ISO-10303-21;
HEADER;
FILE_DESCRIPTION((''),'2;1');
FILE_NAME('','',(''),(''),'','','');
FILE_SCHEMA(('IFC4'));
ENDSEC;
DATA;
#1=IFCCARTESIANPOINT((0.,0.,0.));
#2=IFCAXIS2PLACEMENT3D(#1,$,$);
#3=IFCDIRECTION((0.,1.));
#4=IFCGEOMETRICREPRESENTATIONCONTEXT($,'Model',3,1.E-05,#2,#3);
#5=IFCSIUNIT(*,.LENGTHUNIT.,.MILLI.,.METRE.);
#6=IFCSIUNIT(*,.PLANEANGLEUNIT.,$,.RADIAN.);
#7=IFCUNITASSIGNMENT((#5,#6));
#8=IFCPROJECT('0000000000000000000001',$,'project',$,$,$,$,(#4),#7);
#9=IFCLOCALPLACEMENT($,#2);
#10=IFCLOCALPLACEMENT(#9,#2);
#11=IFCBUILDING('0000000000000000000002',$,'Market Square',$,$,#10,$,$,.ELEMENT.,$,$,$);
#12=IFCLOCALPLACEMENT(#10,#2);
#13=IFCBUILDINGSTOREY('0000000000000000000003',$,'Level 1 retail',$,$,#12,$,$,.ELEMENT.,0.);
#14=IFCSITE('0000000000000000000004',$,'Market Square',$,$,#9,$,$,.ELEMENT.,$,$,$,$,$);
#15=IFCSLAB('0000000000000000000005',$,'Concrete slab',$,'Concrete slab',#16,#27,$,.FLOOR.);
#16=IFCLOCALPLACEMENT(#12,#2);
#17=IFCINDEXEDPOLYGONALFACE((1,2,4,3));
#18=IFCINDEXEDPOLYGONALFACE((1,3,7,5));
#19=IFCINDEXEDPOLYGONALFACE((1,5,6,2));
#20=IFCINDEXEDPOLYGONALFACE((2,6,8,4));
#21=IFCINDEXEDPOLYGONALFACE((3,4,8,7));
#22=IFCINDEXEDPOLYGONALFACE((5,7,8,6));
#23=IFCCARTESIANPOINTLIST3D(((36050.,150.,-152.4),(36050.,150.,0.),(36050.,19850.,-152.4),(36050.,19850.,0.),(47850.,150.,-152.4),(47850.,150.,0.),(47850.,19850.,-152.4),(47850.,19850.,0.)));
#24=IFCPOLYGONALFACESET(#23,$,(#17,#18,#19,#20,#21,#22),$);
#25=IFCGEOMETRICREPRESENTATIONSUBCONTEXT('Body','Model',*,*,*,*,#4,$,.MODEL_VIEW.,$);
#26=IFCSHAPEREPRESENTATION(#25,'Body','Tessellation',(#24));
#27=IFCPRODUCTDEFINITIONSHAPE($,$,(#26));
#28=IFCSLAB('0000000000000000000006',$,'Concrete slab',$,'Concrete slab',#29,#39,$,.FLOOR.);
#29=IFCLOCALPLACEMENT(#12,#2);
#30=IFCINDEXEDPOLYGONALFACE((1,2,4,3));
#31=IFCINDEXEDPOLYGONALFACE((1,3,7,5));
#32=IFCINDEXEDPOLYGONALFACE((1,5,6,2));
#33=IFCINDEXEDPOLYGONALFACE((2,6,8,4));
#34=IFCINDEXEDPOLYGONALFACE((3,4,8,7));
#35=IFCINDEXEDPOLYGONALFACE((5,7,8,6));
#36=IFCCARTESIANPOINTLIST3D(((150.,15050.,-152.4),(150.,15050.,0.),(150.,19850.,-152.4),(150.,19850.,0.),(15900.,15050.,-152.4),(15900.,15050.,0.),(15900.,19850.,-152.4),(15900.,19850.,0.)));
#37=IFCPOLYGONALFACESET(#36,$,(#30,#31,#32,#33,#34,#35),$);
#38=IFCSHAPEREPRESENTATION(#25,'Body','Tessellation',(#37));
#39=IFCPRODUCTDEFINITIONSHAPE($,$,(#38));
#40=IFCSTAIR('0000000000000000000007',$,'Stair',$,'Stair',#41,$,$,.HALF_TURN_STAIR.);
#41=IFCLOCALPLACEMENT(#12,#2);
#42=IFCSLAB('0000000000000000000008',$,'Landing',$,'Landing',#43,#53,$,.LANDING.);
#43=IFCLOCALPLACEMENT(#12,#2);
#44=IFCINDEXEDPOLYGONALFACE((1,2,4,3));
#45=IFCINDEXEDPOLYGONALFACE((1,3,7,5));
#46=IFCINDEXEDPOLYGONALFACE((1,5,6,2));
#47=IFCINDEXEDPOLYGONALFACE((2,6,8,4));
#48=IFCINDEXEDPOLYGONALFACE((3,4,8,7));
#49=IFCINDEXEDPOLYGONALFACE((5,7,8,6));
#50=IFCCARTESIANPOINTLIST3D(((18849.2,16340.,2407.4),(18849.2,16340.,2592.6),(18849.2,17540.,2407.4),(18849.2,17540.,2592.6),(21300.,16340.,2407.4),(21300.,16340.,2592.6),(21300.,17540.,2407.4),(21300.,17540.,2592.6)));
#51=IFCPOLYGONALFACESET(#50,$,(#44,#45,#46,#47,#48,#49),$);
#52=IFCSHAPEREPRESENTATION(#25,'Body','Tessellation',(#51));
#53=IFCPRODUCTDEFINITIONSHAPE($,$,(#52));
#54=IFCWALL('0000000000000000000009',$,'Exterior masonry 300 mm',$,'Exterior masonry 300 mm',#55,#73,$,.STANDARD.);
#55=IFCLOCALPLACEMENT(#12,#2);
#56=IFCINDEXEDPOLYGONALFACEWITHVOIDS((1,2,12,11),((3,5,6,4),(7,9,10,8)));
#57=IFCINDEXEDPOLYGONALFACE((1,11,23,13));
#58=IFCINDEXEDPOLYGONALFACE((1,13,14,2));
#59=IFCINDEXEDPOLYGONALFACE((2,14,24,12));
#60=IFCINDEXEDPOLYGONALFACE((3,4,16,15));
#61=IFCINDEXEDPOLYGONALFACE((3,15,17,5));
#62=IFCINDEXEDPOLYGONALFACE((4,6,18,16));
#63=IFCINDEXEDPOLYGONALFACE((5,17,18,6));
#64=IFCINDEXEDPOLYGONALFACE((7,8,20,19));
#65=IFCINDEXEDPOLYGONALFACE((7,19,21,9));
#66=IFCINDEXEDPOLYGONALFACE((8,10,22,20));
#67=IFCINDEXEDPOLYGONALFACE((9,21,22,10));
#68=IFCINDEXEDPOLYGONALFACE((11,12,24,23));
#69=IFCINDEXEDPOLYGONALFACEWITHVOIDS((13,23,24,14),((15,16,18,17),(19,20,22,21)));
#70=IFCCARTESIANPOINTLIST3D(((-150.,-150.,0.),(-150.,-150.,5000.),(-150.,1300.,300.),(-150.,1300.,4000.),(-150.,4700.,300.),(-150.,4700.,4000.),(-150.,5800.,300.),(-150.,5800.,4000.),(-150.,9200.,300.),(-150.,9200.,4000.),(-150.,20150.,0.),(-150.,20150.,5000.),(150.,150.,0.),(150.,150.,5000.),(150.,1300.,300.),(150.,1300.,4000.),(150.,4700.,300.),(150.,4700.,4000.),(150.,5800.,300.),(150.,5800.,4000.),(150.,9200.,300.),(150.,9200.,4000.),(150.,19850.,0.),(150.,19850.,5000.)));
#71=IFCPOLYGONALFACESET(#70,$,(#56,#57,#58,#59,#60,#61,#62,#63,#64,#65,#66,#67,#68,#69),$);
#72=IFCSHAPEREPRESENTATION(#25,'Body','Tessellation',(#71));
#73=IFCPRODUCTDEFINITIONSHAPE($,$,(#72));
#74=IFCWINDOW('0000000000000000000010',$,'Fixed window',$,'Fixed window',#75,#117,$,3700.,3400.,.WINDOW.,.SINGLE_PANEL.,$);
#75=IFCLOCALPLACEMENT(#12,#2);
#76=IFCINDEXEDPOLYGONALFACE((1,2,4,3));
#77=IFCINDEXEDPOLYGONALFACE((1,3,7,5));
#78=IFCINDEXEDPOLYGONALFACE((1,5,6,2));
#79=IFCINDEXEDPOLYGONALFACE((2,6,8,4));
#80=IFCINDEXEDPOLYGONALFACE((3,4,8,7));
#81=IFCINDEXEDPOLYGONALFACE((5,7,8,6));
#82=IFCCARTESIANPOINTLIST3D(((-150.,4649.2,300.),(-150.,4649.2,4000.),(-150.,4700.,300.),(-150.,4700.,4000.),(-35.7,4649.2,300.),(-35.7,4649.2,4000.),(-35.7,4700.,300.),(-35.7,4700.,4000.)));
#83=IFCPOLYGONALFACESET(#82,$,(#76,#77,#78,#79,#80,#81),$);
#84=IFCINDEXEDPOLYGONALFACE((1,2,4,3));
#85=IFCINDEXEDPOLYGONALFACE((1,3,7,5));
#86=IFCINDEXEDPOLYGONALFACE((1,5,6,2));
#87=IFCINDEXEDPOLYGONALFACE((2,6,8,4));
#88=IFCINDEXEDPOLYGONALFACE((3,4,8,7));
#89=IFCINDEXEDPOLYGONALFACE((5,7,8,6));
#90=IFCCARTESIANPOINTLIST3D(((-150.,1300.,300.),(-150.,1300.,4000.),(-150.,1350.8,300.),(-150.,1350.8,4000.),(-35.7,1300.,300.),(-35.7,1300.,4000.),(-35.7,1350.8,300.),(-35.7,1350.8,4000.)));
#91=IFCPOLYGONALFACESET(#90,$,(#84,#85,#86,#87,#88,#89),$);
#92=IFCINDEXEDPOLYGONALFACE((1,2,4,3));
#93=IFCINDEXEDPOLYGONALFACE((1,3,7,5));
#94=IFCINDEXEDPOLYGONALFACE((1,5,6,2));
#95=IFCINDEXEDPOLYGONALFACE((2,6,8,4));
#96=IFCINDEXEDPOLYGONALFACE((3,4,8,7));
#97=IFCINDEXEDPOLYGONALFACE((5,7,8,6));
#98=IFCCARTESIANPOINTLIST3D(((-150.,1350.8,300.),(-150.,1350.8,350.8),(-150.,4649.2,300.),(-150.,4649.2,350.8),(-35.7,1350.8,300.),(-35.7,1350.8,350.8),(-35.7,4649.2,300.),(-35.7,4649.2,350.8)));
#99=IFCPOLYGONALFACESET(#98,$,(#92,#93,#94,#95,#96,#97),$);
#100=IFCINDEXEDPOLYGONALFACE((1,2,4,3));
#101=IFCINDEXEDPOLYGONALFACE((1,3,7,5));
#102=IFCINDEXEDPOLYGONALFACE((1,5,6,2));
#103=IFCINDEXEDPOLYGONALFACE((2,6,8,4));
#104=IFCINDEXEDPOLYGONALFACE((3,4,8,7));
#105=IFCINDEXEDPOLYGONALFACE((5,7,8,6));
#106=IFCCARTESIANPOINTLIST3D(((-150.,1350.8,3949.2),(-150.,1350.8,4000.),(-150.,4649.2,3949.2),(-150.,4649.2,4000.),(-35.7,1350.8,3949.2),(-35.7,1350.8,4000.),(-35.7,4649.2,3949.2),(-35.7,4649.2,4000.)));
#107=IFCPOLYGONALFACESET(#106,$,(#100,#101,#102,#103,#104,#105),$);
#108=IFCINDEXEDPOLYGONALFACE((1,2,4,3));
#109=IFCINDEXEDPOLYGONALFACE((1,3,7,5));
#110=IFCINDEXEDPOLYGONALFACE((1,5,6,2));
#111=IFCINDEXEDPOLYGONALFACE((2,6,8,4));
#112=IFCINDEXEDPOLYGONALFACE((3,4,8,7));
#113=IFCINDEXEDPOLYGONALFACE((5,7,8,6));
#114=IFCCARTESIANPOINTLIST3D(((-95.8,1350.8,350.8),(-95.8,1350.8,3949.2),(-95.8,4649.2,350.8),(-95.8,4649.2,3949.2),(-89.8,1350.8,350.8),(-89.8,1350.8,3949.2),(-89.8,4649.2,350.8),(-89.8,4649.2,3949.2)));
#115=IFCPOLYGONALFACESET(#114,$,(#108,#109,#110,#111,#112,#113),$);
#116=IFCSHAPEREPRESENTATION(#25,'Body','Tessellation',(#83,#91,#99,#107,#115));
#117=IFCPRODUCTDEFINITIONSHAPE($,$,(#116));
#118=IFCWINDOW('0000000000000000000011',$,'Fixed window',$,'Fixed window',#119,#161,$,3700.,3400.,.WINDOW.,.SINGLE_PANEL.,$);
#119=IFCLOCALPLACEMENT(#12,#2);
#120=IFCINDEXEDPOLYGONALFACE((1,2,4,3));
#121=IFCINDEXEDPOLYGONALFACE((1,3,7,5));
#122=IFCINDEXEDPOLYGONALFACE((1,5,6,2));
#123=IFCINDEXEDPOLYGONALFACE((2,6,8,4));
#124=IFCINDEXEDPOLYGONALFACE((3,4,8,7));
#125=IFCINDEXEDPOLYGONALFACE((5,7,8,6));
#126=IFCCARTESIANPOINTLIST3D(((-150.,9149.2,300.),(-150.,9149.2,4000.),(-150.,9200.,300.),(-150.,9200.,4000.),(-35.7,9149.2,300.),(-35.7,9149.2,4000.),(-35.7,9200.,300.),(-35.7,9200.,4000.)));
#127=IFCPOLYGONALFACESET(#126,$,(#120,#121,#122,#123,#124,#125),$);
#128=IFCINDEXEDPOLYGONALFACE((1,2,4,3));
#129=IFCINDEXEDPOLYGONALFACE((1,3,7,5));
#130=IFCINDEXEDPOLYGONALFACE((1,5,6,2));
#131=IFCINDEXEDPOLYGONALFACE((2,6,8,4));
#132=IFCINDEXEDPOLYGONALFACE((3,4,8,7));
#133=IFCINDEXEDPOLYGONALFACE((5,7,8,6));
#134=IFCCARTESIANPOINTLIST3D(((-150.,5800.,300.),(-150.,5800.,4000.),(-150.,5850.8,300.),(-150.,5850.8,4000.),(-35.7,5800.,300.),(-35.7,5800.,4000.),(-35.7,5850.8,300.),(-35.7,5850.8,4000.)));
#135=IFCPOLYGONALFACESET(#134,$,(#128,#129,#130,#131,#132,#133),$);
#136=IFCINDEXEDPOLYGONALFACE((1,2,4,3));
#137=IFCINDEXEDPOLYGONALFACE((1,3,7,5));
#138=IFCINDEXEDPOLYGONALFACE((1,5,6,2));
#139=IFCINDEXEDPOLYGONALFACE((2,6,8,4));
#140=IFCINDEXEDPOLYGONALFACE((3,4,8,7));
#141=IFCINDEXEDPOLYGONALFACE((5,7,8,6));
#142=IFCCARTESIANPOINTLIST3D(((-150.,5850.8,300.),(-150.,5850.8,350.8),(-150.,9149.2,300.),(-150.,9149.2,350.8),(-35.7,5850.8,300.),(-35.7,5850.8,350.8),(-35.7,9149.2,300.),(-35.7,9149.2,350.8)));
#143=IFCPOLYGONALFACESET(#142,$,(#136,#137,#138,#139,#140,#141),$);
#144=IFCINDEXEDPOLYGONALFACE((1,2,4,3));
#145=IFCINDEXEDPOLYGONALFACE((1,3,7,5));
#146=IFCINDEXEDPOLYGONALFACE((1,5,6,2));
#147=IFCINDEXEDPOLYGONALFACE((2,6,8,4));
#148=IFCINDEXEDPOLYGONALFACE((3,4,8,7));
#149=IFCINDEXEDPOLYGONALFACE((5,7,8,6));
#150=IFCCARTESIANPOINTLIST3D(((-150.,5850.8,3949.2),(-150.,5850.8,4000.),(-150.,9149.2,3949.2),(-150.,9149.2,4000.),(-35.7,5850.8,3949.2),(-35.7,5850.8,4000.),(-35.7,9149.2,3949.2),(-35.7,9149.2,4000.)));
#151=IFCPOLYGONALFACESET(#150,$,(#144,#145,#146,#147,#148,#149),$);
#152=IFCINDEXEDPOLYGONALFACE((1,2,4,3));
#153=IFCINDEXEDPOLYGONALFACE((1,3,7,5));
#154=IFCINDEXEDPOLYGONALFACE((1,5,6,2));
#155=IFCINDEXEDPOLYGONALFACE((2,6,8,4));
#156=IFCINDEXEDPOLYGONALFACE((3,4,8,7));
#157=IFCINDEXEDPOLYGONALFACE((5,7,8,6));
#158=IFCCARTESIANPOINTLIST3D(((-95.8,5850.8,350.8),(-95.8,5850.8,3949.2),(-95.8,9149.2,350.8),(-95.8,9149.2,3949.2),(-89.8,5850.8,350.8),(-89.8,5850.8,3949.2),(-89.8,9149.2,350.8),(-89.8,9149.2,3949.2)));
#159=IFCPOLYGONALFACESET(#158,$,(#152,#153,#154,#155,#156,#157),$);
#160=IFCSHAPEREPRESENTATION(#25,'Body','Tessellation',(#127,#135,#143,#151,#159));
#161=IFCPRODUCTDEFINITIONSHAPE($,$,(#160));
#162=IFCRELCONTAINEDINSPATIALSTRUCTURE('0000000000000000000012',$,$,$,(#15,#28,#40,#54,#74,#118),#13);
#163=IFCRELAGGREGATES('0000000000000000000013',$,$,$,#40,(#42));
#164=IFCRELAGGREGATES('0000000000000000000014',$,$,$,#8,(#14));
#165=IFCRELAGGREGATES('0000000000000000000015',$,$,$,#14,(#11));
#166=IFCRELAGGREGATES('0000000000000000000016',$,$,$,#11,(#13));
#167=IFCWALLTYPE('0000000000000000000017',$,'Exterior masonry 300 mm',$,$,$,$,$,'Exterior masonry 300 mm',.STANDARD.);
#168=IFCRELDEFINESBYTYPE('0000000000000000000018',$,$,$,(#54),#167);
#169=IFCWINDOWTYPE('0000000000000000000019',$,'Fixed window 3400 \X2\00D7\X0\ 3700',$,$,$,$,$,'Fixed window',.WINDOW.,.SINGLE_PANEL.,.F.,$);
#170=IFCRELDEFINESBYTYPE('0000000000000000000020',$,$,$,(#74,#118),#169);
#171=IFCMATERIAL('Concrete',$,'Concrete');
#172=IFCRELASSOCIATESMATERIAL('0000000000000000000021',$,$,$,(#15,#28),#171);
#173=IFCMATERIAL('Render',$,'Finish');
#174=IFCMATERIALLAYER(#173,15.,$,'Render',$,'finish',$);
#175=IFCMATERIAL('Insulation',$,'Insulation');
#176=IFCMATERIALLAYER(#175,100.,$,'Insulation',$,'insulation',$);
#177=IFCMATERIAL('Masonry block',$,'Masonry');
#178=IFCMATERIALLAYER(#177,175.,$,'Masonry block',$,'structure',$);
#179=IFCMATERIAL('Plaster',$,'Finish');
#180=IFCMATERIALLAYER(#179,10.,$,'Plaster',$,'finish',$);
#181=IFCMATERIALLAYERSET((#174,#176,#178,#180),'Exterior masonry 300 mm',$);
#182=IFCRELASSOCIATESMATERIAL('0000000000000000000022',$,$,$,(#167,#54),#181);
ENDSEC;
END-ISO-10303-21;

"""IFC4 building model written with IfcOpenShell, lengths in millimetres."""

from ifc_helpers import new_model, si_unit, direction, frame, origin, origin_with_axes, place, context, subcontext, project, spatial, polyline, outline, extrude, material, layer, layer_set, layer_usage, type_object, element, fill, aggregate, save


model = new_model("IFC4")

# Units and contexts
model_context = context("Model", 3, precision=1e-05, world=origin(), true_north=direction((0.0, 1.0)))
body_context = subcontext(model_context, "Body", "Model", "MODEL_VIEW")
ifc_project = project(units=[si_unit("LENGTHUNIT", "METRE", prefix="MILLI"), si_unit("PLANEANGLEUNIT", "RADIAN")], contexts=[model_context])

# Site, building, storey
site_placement = place(None, origin())
site = spatial("IfcSite", under=ifc_project, at=site_placement, Name="Market Square", CompositionType="ELEMENT")
building_placement = place(site_placement, origin())
building = spatial("IfcBuilding", under=site, at=building_placement, Name="Market Square", CompositionType="ELEMENT")
storey_placement = place(building_placement, origin())
storey = spatial("IfcBuildingStorey", under=building, at=storey_placement, Name="Level 1 retail", CompositionType="ELEMENT", Elevation=0.0)

# Slabs
ifc_material_1 = material(Name="Concrete", Category="Concrete")
slab_1_placement = place(storey_placement, origin_with_axes())
element("IfcSlab", 1, at=slab_1_placement, inside=storey, material=ifc_material_1, Name="Concrete slab", ObjectType="Concrete slab", PredefinedType="FLOOR", context=body_context, shape_type="SweptSolid", body=[
    extrude(outline(polyline([(36050.0, 150.0), (47850.0, 150.0), (47850.0, 19850.0), (36050.0, 19850.0), (36050.0, 150.0)])), frame((0.0, 0.0, -152.4)), (0.0, 0.0, 1.0), 152.4),
])
slab_2_placement = place(storey_placement, origin_with_axes())
element("IfcSlab", 2, at=slab_2_placement, inside=storey, material=ifc_material_1, Name="Concrete slab", ObjectType="Concrete slab", PredefinedType="FLOOR", context=body_context, shape_type="SweptSolid", body=[
    extrude(outline(polyline([(15900.0, 19850.0), (150.0, 19850.0), (150.0, 15050.0), (15900.0, 15050.0), (15900.0, 19850.0)])), frame((0.0, 0.0, -152.4)), (0.0, 0.0, 1.0), 152.4),
])

# Stair, slab
stair_placement = place(storey_placement, origin_with_axes())
stair = element("IfcStair", 3, at=stair_placement, inside=storey, Name="Stair", ObjectType="Stair", PredefinedType="HALF_TURN_STAIR")
slab_3_placement = place(storey_placement, origin_with_axes())
slab_3 = element("IfcSlab", 4, at=slab_3_placement, Name="Landing", ObjectType="Landing", PredefinedType="LANDING", context=body_context, shape_type="SweptSolid", body=[
    extrude(outline(polyline([(21300.0, 16340.0), (21300.0, 17540.0), (18849.2, 17540.0), (18849.2, 16340.0), (21300.0, 16340.0)])), frame((0.0, 0.0, 2407.4)), (0.0, 0.0, 1.0), 185.2),
])

# Wall, openings, windows
ifc_material_2 = material(Name="Render", Category="Finish")
ifc_layer_1 = layer(ifc_material_2, 15.0, Name="Render", Category="finish")
ifc_material_3 = material(Name="Insulation", Category="Insulation")
ifc_layer_2 = layer(ifc_material_3, 100.0, Name="Insulation", Category="insulation")
ifc_material_4 = material(Name="Masonry block", Category="Masonry")
ifc_layer_3 = layer(ifc_material_4, 175.0, Name="Masonry block", Category="structure")
ifc_material_5 = material(Name="Plaster", Category="Finish")
ifc_layer_4 = layer(ifc_material_5, 10.0, Name="Plaster", Category="finish")
ifc_layer_set_1 = layer_set([ifc_layer_1, ifc_layer_2, ifc_layer_3, ifc_layer_4], Name="Exterior masonry 300 mm")
ifc_layer_usage_1 = layer_usage(ifc_layer_set_1, "AXIS2", "POSITIVE", -150.0)
wall_type_1 = type_object("IfcWallType", Name="Exterior masonry 300 mm", ElementType="Exterior masonry 300 mm", PredefinedType="STANDARD", material=ifc_layer_set_1)
wall_1_placement = place(storey_placement, frame((0.0, 20000.0, 0.0), z_axis=(0.0, 0.0, 1.0), x_axis=(0.0, -1.0, 0.0)))
wall_1 = element("IfcWall", 5, at=wall_1_placement, inside=storey, type_object=wall_type_1, material=ifc_layer_usage_1, Name="Exterior masonry 300 mm", ObjectType="Exterior masonry 300 mm", PredefinedType="STANDARD", context=body_context, shape_type="SweptSolid", body=[
    extrude(outline(polyline([(-150.0, -150.0), (20150.0, -150.0), (19850.0, 150.0), (150.0, 150.0), (-150.0, -150.0)])), origin(), (0.0, 0.0, 1.0), 5000.0),
])
opening_1_placement = place(wall_1_placement, frame((15300.0, 0.0, 300.0), z_axis=(0.0, 0.0, 1.0), x_axis=(1.0, 0.0, 0.0)))
opening_1 = element("IfcOpeningElement", 6, at=opening_1_placement, cuts=wall_1, PredefinedType="OPENING", context=body_context, shape_type="SweptSolid", body=[
    extrude(outline(polyline([(0.0, -160.0), (3400.0, -160.0), (3400.0, 160.0), (0.0, 160.0), (0.0, -160.0)])), origin(), (0.0, 0.0, 1.0), 3700.0),
])
opening_2_placement = place(wall_1_placement, frame((10800.0, 0.0, 300.0), z_axis=(0.0, 0.0, 1.0), x_axis=(1.0, 0.0, 0.0)))
opening_2 = element("IfcOpeningElement", 7, at=opening_2_placement, cuts=wall_1, PredefinedType="OPENING", context=body_context, shape_type="SweptSolid", body=[
    extrude(outline(polyline([(0.0, -160.0), (3400.0, -160.0), (3400.0, 160.0), (0.0, 160.0), (0.0, -160.0)])), origin(), (0.0, 0.0, 1.0), 3700.0),
])
window_type = type_object("IfcWindowType", Name="Fixed window 3400 × 3700", ElementType="Fixed window", ParameterTakesPrecedence=False, PartitioningType="SINGLE_PANEL", PredefinedType="WINDOW")
window_1_placement = place(opening_1_placement, origin_with_axes())
window_1 = element("IfcWindow", 8, at=window_1_placement, inside=storey, type_object=window_type, Name="Fixed window", ObjectType="Fixed window", OverallHeight=3700.0, OverallWidth=3400.0, PartitioningType="SINGLE_PANEL", PredefinedType="WINDOW", context=body_context, shape_type="SweptSolid", body=[
    extrude(outline(polyline([(0.0, -150.0), (50.8, -150.0), (50.8, -35.7), (0.0, -35.7), (0.0, -150.0)])), origin(), (0.0, 0.0, 1.0), 3700.0),
    extrude(outline(polyline([(3349.2, -150.0), (3400.0, -150.0), (3400.0, -35.7), (3349.2, -35.7), (3349.2, -150.0)])), origin(), (0.0, 0.0, 1.0), 3700.0),
    extrude(outline(polyline([(50.8, -150.0), (3349.2, -150.0), (3349.2, -35.7), (50.8, -35.7), (50.8, -150.0)])), origin(), (0.0, 0.0, 1.0), 50.8),
    extrude(outline(polyline([(50.8, -150.0), (3349.2, -150.0), (3349.2, -35.7), (50.8, -35.7), (50.8, -150.0)])), frame((0.0, 0.0, 3649.2)), (0.0, 0.0, 1.0), 50.8),
    extrude(outline(polyline([(50.8, -95.8), (3349.2, -95.8), (3349.2, -89.8), (50.8, -89.8), (50.8, -95.8)])), frame((0.0, 0.0, 50.8)), (0.0, 0.0, 1.0), 3598.4),
])
fill(opening_1, window_1)
window_2_placement = place(opening_2_placement, origin_with_axes())
window_2 = element("IfcWindow", 9, at=window_2_placement, inside=storey, type_object=window_type, Name="Fixed window", ObjectType="Fixed window", OverallHeight=3700.0, OverallWidth=3400.0, PartitioningType="SINGLE_PANEL", PredefinedType="WINDOW", context=body_context, shape_type="SweptSolid", body=[
    extrude(outline(polyline([(0.0, -150.0), (50.8, -150.0), (50.8, -35.7), (0.0, -35.7), (0.0, -150.0)])), origin(), (0.0, 0.0, 1.0), 3700.0),
    extrude(outline(polyline([(3349.2, -150.0), (3400.0, -150.0), (3400.0, -35.7), (3349.2, -35.7), (3349.2, -150.0)])), origin(), (0.0, 0.0, 1.0), 3700.0),
    extrude(outline(polyline([(50.8, -150.0), (3349.2, -150.0), (3349.2, -35.7), (50.8, -35.7), (50.8, -150.0)])), origin(), (0.0, 0.0, 1.0), 50.8),
    extrude(outline(polyline([(50.8, -150.0), (3349.2, -150.0), (3349.2, -35.7), (50.8, -35.7), (50.8, -150.0)])), frame((0.0, 0.0, 3649.2)), (0.0, 0.0, 1.0), 50.8),
    extrude(outline(polyline([(50.8, -95.8), (3349.2, -95.8), (3349.2, -89.8), (50.8, -89.8), (50.8, -95.8)])), frame((0.0, 0.0, 50.8)), (0.0, 0.0, 1.0), 3598.4),
])
fill(opening_2, window_2)

aggregate(stair, [slab_3])

save(model, "model.ifc")
